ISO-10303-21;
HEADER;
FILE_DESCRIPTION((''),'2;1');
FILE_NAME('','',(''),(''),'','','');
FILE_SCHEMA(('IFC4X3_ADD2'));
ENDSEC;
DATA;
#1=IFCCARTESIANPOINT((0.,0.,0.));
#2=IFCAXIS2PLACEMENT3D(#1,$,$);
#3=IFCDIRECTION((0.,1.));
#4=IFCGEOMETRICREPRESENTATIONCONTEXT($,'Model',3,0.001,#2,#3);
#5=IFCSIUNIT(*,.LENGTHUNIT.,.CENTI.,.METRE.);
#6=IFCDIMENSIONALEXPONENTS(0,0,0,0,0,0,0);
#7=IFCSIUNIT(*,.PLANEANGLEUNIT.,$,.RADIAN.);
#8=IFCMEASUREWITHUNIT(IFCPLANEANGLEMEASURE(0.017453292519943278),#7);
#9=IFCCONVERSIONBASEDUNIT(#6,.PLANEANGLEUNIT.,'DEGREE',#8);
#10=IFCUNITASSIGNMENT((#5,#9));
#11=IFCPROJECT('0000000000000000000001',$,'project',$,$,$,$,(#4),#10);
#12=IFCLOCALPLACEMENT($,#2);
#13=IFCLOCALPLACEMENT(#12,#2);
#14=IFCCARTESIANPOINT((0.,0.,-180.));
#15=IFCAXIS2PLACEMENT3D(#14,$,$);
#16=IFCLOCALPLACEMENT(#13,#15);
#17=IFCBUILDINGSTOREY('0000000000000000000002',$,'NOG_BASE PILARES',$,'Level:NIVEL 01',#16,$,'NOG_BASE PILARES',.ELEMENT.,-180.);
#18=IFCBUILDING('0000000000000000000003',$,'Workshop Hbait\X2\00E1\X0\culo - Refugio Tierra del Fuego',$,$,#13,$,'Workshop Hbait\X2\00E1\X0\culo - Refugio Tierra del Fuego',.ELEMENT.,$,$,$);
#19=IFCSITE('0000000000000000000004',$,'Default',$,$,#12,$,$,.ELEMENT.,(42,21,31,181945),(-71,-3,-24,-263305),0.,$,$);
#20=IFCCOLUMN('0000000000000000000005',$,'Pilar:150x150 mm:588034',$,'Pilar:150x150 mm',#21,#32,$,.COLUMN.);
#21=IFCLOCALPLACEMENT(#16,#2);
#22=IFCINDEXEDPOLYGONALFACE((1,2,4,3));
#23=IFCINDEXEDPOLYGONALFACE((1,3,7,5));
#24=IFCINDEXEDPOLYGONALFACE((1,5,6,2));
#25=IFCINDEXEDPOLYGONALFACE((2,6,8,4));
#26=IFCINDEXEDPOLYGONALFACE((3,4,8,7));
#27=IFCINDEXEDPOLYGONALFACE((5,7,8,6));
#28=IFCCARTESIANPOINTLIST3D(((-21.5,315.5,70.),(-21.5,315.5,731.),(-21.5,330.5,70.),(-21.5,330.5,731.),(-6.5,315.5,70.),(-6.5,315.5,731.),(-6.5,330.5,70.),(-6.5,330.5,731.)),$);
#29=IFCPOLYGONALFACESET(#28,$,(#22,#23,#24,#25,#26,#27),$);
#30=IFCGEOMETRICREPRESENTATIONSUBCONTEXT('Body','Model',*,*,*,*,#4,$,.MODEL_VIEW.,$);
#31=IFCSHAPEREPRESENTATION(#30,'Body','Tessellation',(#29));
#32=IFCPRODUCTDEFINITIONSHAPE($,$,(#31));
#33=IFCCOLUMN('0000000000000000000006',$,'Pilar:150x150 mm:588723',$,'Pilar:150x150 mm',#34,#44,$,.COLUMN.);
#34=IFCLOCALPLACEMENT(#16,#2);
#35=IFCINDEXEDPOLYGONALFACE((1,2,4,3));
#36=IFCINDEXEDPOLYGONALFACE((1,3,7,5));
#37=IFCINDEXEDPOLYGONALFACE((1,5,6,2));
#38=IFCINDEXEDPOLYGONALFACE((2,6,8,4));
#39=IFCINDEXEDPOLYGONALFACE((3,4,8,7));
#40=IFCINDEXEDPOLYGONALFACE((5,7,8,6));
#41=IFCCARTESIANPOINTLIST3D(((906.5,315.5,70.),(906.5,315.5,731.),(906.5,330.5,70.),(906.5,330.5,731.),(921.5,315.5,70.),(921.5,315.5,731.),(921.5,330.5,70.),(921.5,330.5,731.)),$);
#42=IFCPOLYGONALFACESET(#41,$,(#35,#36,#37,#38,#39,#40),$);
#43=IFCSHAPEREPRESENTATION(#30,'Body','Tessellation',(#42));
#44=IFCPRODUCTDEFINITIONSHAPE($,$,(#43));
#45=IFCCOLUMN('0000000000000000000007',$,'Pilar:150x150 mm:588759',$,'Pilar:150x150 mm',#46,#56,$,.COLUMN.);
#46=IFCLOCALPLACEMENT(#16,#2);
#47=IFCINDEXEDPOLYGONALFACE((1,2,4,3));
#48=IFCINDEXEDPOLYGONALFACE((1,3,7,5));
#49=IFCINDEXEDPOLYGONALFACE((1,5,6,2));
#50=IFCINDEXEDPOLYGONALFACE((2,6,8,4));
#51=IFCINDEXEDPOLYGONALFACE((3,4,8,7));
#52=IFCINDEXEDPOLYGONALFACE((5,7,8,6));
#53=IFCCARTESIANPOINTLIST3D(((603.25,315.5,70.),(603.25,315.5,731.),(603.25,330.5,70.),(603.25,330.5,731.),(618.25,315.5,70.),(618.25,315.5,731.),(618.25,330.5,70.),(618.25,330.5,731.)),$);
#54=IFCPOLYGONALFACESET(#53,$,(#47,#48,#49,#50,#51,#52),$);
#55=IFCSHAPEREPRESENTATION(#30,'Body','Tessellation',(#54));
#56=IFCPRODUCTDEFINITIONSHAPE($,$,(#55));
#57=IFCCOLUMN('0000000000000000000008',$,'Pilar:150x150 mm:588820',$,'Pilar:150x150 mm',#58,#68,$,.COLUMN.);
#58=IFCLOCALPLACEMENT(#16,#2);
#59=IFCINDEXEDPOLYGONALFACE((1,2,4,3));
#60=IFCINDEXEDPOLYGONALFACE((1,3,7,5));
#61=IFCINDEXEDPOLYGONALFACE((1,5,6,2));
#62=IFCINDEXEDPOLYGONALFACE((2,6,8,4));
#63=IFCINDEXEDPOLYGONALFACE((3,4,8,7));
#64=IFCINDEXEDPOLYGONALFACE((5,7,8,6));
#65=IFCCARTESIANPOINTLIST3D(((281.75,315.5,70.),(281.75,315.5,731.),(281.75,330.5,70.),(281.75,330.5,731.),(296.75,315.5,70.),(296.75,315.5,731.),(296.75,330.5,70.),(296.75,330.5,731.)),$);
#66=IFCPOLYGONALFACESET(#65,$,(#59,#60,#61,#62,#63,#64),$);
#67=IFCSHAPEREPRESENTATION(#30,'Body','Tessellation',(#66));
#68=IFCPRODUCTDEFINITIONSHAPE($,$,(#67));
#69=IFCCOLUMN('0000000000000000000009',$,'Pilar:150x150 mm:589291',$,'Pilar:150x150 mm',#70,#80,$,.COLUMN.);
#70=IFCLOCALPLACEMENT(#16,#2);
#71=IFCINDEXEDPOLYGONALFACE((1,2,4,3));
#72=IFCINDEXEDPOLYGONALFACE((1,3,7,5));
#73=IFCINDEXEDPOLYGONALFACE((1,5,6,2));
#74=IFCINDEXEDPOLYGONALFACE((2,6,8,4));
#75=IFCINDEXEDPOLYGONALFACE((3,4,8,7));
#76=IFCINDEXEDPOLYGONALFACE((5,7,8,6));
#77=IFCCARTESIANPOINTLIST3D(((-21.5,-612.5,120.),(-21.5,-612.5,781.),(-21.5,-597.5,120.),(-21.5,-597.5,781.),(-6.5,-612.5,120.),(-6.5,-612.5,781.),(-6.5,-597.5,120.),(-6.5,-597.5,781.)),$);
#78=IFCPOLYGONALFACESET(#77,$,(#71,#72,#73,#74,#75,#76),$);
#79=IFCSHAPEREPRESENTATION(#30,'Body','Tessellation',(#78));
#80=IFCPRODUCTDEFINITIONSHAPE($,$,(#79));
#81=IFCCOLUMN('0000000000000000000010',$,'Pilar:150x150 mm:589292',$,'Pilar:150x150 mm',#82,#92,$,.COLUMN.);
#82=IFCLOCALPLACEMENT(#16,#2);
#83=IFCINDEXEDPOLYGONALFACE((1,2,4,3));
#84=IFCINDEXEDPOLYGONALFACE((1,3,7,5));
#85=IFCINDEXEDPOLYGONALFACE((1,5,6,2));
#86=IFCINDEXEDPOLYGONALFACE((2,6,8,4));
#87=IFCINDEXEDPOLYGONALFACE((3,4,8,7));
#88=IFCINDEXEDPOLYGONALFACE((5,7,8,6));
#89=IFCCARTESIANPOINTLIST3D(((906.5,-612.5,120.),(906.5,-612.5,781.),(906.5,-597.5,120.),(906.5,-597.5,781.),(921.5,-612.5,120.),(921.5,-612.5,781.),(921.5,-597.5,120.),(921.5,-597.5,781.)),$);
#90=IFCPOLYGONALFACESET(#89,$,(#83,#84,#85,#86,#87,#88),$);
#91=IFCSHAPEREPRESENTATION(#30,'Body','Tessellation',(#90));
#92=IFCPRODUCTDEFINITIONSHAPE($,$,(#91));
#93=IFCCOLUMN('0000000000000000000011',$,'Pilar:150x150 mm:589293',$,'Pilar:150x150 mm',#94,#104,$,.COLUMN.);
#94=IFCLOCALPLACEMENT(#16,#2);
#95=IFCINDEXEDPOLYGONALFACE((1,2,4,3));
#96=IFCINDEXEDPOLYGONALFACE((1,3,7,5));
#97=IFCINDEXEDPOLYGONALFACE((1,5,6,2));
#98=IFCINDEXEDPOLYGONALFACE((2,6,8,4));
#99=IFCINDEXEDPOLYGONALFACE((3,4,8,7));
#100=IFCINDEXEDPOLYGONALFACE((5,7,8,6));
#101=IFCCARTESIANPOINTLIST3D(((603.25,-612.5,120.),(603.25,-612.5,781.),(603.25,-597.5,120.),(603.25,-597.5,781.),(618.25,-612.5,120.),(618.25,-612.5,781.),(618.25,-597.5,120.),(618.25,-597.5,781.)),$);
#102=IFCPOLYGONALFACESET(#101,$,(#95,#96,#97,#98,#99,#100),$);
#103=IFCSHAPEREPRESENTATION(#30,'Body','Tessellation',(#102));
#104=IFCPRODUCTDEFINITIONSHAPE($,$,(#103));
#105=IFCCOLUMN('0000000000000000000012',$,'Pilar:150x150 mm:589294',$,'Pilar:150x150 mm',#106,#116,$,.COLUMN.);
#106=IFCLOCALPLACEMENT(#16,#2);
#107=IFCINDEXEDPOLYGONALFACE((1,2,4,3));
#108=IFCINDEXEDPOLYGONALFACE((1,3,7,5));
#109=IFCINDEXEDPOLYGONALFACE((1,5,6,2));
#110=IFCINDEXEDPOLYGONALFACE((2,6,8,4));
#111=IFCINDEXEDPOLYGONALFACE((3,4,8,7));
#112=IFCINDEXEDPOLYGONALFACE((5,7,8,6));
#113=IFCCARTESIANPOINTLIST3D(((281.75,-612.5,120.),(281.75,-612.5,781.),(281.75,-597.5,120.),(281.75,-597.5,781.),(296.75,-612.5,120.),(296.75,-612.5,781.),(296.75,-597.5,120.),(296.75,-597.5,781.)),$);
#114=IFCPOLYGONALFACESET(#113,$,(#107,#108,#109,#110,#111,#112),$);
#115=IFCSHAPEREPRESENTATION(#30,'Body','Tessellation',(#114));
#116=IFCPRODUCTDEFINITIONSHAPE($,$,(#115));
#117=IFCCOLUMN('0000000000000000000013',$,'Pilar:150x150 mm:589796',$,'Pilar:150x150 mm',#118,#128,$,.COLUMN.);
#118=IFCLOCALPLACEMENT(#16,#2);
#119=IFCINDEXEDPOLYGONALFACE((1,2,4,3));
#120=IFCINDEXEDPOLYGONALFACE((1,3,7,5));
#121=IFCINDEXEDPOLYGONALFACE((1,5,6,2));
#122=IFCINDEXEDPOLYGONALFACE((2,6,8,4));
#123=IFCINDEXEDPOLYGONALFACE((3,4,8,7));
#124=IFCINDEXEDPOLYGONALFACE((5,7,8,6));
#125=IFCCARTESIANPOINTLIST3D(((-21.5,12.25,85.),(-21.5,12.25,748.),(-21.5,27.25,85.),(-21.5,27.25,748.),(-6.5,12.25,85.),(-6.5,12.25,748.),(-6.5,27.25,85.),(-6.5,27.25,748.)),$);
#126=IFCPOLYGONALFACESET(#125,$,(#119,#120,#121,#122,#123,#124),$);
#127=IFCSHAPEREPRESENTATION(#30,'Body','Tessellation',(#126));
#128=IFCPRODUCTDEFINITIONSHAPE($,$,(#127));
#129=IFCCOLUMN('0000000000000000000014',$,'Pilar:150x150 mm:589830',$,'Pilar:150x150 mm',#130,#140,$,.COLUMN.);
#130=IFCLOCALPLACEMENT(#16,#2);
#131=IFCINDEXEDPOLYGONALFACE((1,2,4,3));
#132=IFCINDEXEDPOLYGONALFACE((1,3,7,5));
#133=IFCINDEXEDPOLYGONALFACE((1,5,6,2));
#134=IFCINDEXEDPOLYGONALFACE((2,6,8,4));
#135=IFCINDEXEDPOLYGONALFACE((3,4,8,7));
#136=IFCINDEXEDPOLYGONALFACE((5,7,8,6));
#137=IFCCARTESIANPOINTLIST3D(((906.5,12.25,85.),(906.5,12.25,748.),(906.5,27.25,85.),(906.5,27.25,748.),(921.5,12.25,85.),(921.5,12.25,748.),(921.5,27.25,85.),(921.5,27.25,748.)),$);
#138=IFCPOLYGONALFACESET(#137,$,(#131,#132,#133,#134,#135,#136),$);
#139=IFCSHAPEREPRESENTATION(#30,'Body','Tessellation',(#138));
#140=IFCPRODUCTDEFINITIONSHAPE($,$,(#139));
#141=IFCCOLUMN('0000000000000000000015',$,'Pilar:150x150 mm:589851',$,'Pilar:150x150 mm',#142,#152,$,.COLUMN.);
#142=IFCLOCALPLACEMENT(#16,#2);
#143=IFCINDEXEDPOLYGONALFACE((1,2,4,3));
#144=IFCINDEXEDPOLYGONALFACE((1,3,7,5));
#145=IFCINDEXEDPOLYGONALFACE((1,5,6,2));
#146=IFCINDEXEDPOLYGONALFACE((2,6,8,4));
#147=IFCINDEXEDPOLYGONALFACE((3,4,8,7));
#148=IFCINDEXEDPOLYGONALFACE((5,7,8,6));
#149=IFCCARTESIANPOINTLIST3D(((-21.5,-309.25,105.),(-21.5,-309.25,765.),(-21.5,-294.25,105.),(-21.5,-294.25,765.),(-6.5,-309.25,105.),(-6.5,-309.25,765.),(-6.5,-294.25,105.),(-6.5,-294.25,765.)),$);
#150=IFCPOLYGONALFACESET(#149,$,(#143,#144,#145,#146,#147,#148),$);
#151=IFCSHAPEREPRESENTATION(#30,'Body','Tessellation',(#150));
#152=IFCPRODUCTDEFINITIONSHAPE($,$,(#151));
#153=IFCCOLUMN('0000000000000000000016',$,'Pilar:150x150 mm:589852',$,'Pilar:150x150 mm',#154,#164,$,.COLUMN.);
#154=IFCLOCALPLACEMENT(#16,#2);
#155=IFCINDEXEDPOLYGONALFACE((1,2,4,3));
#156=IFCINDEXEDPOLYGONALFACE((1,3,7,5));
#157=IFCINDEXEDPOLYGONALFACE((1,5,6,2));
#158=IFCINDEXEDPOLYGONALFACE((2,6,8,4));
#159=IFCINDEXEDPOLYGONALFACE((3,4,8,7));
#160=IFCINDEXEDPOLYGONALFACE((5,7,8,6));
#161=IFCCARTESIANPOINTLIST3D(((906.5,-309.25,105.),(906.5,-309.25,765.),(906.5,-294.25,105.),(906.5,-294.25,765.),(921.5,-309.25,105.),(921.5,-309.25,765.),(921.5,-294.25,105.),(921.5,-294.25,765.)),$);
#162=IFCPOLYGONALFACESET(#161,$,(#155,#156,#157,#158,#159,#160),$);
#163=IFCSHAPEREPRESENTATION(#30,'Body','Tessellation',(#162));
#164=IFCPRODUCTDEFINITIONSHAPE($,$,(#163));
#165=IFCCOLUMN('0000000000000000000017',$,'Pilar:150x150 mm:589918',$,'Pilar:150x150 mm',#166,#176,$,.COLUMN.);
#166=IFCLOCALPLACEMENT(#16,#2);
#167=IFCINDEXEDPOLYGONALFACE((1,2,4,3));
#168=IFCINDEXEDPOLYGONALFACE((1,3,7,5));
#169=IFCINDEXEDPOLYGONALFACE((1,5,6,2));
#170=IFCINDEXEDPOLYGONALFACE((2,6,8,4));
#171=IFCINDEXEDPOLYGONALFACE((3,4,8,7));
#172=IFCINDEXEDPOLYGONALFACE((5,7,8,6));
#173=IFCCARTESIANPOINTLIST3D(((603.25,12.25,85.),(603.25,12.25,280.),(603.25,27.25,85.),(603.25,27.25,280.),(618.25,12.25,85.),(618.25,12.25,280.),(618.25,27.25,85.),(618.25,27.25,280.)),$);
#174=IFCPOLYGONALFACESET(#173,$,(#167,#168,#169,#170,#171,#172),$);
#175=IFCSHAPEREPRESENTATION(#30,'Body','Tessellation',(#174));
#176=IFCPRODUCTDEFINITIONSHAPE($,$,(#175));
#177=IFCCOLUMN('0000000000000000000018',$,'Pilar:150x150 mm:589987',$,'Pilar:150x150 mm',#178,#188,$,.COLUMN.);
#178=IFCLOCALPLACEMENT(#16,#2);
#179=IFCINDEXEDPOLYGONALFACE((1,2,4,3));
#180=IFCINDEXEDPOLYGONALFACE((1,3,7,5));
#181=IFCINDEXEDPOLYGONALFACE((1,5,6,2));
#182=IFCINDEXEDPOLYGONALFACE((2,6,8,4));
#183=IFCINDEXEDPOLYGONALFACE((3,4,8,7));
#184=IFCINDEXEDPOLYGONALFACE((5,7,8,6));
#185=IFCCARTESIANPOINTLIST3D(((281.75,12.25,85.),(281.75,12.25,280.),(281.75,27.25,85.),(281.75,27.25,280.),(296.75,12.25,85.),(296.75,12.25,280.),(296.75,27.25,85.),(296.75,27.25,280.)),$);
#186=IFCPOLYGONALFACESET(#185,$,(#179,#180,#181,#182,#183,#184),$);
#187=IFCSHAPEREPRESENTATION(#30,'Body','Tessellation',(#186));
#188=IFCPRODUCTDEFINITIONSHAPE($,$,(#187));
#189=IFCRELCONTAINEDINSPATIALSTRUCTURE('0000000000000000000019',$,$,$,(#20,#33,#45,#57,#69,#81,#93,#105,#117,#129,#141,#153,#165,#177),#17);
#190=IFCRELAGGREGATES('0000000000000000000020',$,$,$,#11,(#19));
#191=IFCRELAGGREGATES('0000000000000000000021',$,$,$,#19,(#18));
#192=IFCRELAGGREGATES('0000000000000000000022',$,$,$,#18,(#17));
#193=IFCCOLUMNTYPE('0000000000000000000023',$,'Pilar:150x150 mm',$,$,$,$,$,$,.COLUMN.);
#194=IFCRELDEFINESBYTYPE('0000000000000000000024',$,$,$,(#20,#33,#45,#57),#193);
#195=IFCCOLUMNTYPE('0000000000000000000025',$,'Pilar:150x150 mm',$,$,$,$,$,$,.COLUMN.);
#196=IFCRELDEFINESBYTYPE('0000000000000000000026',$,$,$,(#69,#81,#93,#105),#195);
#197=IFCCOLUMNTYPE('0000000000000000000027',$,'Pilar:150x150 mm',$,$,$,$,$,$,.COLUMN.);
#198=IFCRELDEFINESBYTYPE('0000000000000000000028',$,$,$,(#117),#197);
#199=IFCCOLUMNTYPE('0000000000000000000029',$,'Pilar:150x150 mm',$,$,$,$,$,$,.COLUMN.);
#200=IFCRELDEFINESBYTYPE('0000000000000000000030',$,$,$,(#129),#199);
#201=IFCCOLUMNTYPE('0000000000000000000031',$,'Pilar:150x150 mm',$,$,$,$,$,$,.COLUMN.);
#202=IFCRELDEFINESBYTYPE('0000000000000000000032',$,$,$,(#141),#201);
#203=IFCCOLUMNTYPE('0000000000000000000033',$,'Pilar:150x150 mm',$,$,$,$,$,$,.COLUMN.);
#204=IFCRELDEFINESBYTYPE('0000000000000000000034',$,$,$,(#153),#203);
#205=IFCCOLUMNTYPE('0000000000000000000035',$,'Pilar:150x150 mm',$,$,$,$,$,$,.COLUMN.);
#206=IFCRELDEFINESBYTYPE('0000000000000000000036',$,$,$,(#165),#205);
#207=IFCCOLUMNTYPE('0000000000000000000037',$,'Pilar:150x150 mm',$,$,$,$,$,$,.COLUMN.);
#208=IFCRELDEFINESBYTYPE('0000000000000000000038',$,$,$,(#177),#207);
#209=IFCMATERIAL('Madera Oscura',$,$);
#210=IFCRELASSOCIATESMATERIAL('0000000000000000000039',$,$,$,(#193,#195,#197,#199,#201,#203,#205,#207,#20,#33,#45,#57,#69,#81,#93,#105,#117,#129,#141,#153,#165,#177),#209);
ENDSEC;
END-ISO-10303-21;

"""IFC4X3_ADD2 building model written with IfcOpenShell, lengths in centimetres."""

from ifc_helpers import new_model, entity, si_unit, converted_unit, direction, frame, origin, origin_2d_with_axis, place, context, subcontext, project, spatial, rectangle, extrude, source, transform, mapped, material, material_profile, profile_set, profile_usage, type_object, type_shapes, element, save


model = new_model("IFC4X3_ADD2")

# Units and contexts
model_context = context("Model", 3, precision=0.001, world=origin(), true_north=direction((0.0, 1.0)))
body_context = subcontext(model_context, "Body", "Model", "MODEL_VIEW")
ifc_project = project(units=[si_unit("LENGTHUNIT", "METRE", prefix="CENTI"), converted_unit("PLANEANGLEUNIT", "DEGREE", entity("IfcPlaneAngleMeasure", 0.017453292519943278), si_unit("PLANEANGLEUNIT", "RADIAN"), dimensions=[0, 0, 0, 0, 0, 0, 0])], contexts=[model_context])

# Site, building, storey
site_placement = place(None, origin())
site = spatial("IfcSite", under=ifc_project, at=site_placement, Name="Default", CompositionType="ELEMENT", RefLatitude=(42, 21, 31, 181945), RefLongitude=(-71, -3, -24, -263305), RefElevation=0.0)
building_placement = place(site_placement, origin())
building = spatial("IfcBuilding", under=site, at=building_placement, Name="Workshop Hbaitáculo - Refugio Tierra del Fuego", LongName="Workshop Hbaitáculo - Refugio Tierra del Fuego", CompositionType="ELEMENT")
storey_placement = place(building_placement, frame((0.0, 0.0, -180.0)))
storey = spatial("IfcBuildingStorey", under=building, at=storey_placement, Name="NOG_BASE PILARES", ObjectType="Level:NIVEL 01", LongName="NOG_BASE PILARES", CompositionType="ELEMENT", Elevation=-180.0)

# Columns
ifc_material = material(Name="Madera Oscura")
ifc_material_profile = material_profile(ifc_material, rectangle(XDim=15.0, YDim=15.0, at=origin_2d_with_axis()), Name="150x150 mm")
ifc_profile_set = profile_set([ifc_material_profile], Name="150x150 mm")
ifc_profile_usage = profile_usage(ifc_profile_set)
column_type_1 = type_object("IfcColumnType", Name="Pilar:150x150 mm", PredefinedType="COLUMN", material=ifc_profile_set)
shared_shape_1 = source(origin(), body_context, "Body", "SweptSolid", [
    extrude(rectangle(XDim=15.0, YDim=15.0, at=origin_2d_with_axis()), frame((0.0, 0.0, -110.0), z_axis=(0.0, 0.0, 1.0), x_axis=(-1.0, 0.0, 0.0)), (0.0, 0.0, 1.0), 661.0),
])
type_shapes(column_type_1, [shared_shape_1])
for number, where, name in (
    (1, (-14.0, 323.0, 180.0), "Pilar:150x150 mm:588034"),
    (2, (914.0, 323.0, 180.0), "Pilar:150x150 mm:588723"),
    (3, (610.75, 323.0, 180.0), "Pilar:150x150 mm:588759"),
    (4, (289.25, 323.0, 180.0), "Pilar:150x150 mm:588820"),
):
    element("IfcColumn", number, at=place(storey_placement, frame(where)), inside=storey, type_object=column_type_1, material=ifc_profile_usage, Name=name, ObjectType="Pilar:150x150 mm", PredefinedType="COLUMN", context=body_context, shape_type="MappedRepresentation", body=[
        mapped(shared_shape_1, transform((0.0, 0.0, 0.0), scale=1.0)),
    ])
column_type_2 = type_object("IfcColumnType", Name="Pilar:150x150 mm", PredefinedType="COLUMN", material=ifc_profile_set)
shared_shape_2 = source(origin(), body_context, "Body", "SweptSolid", [
    extrude(rectangle(XDim=15.0, YDim=15.0, at=origin_2d_with_axis()), frame((0.0, 0.0, -60.0), z_axis=(0.0, 0.0, 1.0), x_axis=(0.0, 1.0, 0.0)), (0.0, 0.0, 1.0), 661.0),
])
type_shapes(column_type_2, [shared_shape_2])
for number, where, name in (
    (5, (-14.0, -605.0, 180.0), "Pilar:150x150 mm:589291"),
    (6, (914.0, -605.0, 180.0), "Pilar:150x150 mm:589292"),
    (7, (610.75, -605.0, 180.0), "Pilar:150x150 mm:589293"),
    (8, (289.25, -605.0, 180.0), "Pilar:150x150 mm:589294"),
):
    element("IfcColumn", number, at=place(storey_placement, frame(where)), inside=storey, type_object=column_type_2, material=ifc_profile_usage, Name=name, ObjectType="Pilar:150x150 mm", PredefinedType="COLUMN", context=body_context, shape_type="MappedRepresentation", body=[
        mapped(shared_shape_2, transform((0.0, 0.0, 0.0), scale=1.0)),
    ])
column_type_3 = type_object("IfcColumnType", Name="Pilar:150x150 mm", PredefinedType="COLUMN", material=ifc_profile_set)
shared_shape_3 = source(origin(), body_context, "Body", "SweptSolid", [
    extrude(rectangle(XDim=15.0, YDim=15.0, at=origin_2d_with_axis()), frame((0.0, 0.0, -95.0), z_axis=(0.0, 0.0, 1.0), x_axis=(-1.0, 0.0, 0.0)), (0.0, 0.0, 1.0), 663.0),
])
type_shapes(column_type_3, [shared_shape_3])
column_1_placement = place(storey_placement, frame((-14.0, 19.75, 180.0)))
element("IfcColumn", 9, at=column_1_placement, inside=storey, type_object=column_type_3, material=ifc_profile_usage, Name="Pilar:150x150 mm:589796", ObjectType="Pilar:150x150 mm", PredefinedType="COLUMN", context=body_context, shape_type="MappedRepresentation", body=[
    mapped(shared_shape_3, transform((0.0, 0.0, 0.0), scale=1.0)),
])
column_type_4 = type_object("IfcColumnType", Name="Pilar:150x150 mm", PredefinedType="COLUMN", material=ifc_profile_set)
shared_shape_4 = source(origin(), body_context, "Body", "SweptSolid", [
    extrude(rectangle(XDim=15.0, YDim=15.0, at=origin_2d_with_axis()), frame((0.0, 0.0, -95.0), z_axis=(0.0, 0.0, 1.0), x_axis=(0.0, 1.0, 0.0)), (0.0, 0.0, 1.0), 663.0),
])
type_shapes(column_type_4, [shared_shape_4])
column_2_placement = place(storey_placement, frame((914.0, 19.75, 180.0), z_axis=(0.0, 0.0, 1.0), x_axis=(-1.0, 0.0, 0.0)))
element("IfcColumn", 10, at=column_2_placement, inside=storey, type_object=column_type_4, material=ifc_profile_usage, Name="Pilar:150x150 mm:589830", ObjectType="Pilar:150x150 mm", PredefinedType="COLUMN", context=body_context, shape_type="MappedRepresentation", body=[
    mapped(shared_shape_4, transform((0.0, 0.0, 0.0), scale=1.0)),
])
column_type_5 = type_object("IfcColumnType", Name="Pilar:150x150 mm", PredefinedType="COLUMN", material=ifc_profile_set)
shared_shape_5 = source(origin(), body_context, "Body", "SweptSolid", [
    extrude(rectangle(XDim=15.0, YDim=15.0, at=origin_2d_with_axis()), frame((0.0, 0.0, -75.0), z_axis=(0.0, 0.0, 1.0), x_axis=(0.0, 1.0, 0.0)), (0.0, 0.0, 1.0), 660.0),
])
type_shapes(column_type_5, [shared_shape_5])
column_3_placement = place(storey_placement, frame((-14.0, -301.75, 180.0)))
element("IfcColumn", 11, at=column_3_placement, inside=storey, type_object=column_type_5, material=ifc_profile_usage, Name="Pilar:150x150 mm:589851", ObjectType="Pilar:150x150 mm", PredefinedType="COLUMN", context=body_context, shape_type="MappedRepresentation", body=[
    mapped(shared_shape_5, transform((0.0, 0.0, 0.0), scale=1.0)),
])
column_type_6 = type_object("IfcColumnType", Name="Pilar:150x150 mm", PredefinedType="COLUMN", material=ifc_profile_set)
shared_shape_6 = source(origin(), body_context, "Body", "SweptSolid", [
    extrude(rectangle(XDim=15.0, YDim=15.0, at=origin_2d_with_axis()), frame((0.0, 0.0, -75.0), z_axis=(0.0, 0.0, 1.0), x_axis=(-1.0, 0.0, 0.0)), (0.0, 0.0, 1.0), 660.0),
])
type_shapes(column_type_6, [shared_shape_6])
column_4_placement = place(storey_placement, frame((914.0, -301.75, 180.0), z_axis=(0.0, 0.0, 1.0), x_axis=(-1.0, 0.0, 0.0)))
element("IfcColumn", 12, at=column_4_placement, inside=storey, type_object=column_type_6, material=ifc_profile_usage, Name="Pilar:150x150 mm:589852", ObjectType="Pilar:150x150 mm", PredefinedType="COLUMN", context=body_context, shape_type="MappedRepresentation", body=[
    mapped(shared_shape_6, transform((0.0, 0.0, 0.0), scale=1.0)),
])
column_type_7 = type_object("IfcColumnType", Name="Pilar:150x150 mm", PredefinedType="COLUMN", material=ifc_profile_set)
shared_shape_7 = source(origin(), body_context, "Body", "SweptSolid", [
    extrude(rectangle(XDim=15.0, YDim=15.0, at=origin_2d_with_axis()), frame((0.0, 0.0, -95.0), z_axis=(0.0, 0.0, 1.0), x_axis=(0.0, 1.0, 0.0)), (0.0, 0.0, 1.0), 195.0),
])
type_shapes(column_type_7, [shared_shape_7])
column_5_placement = place(storey_placement, frame((610.75, 19.75, 180.0), z_axis=(0.0, 0.0, 1.0), x_axis=(-1.0, 0.0, 0.0)))
element("IfcColumn", 13, at=column_5_placement, inside=storey, type_object=column_type_7, material=ifc_profile_usage, Name="Pilar:150x150 mm:589918", ObjectType="Pilar:150x150 mm", PredefinedType="COLUMN", context=body_context, shape_type="MappedRepresentation", body=[
    mapped(shared_shape_7, transform((0.0, 0.0, 0.0), scale=1.0)),
])
column_type_8 = type_object("IfcColumnType", Name="Pilar:150x150 mm", PredefinedType="COLUMN", material=ifc_profile_set)
shared_shape_8 = source(origin(), body_context, "Body", "SweptSolid", [
    extrude(rectangle(XDim=15.0, YDim=15.0, at=origin_2d_with_axis()), frame((0.0, 0.0, -95.0), z_axis=(0.0, 0.0, 1.0), x_axis=(-1.0, 0.0, 0.0)), (0.0, 0.0, 1.0), 195.0),
])
type_shapes(column_type_8, [shared_shape_8])
column_6_placement = place(storey_placement, frame((289.25, 19.75, 180.0)))
element("IfcColumn", 14, at=column_6_placement, inside=storey, type_object=column_type_8, material=ifc_profile_usage, Name="Pilar:150x150 mm:589987", ObjectType="Pilar:150x150 mm", PredefinedType="COLUMN", context=body_context, shape_type="MappedRepresentation", body=[
    mapped(shared_shape_8, transform((0.0, 0.0, 0.0), scale=1.0)),
])

save(model, "model.ifc")
